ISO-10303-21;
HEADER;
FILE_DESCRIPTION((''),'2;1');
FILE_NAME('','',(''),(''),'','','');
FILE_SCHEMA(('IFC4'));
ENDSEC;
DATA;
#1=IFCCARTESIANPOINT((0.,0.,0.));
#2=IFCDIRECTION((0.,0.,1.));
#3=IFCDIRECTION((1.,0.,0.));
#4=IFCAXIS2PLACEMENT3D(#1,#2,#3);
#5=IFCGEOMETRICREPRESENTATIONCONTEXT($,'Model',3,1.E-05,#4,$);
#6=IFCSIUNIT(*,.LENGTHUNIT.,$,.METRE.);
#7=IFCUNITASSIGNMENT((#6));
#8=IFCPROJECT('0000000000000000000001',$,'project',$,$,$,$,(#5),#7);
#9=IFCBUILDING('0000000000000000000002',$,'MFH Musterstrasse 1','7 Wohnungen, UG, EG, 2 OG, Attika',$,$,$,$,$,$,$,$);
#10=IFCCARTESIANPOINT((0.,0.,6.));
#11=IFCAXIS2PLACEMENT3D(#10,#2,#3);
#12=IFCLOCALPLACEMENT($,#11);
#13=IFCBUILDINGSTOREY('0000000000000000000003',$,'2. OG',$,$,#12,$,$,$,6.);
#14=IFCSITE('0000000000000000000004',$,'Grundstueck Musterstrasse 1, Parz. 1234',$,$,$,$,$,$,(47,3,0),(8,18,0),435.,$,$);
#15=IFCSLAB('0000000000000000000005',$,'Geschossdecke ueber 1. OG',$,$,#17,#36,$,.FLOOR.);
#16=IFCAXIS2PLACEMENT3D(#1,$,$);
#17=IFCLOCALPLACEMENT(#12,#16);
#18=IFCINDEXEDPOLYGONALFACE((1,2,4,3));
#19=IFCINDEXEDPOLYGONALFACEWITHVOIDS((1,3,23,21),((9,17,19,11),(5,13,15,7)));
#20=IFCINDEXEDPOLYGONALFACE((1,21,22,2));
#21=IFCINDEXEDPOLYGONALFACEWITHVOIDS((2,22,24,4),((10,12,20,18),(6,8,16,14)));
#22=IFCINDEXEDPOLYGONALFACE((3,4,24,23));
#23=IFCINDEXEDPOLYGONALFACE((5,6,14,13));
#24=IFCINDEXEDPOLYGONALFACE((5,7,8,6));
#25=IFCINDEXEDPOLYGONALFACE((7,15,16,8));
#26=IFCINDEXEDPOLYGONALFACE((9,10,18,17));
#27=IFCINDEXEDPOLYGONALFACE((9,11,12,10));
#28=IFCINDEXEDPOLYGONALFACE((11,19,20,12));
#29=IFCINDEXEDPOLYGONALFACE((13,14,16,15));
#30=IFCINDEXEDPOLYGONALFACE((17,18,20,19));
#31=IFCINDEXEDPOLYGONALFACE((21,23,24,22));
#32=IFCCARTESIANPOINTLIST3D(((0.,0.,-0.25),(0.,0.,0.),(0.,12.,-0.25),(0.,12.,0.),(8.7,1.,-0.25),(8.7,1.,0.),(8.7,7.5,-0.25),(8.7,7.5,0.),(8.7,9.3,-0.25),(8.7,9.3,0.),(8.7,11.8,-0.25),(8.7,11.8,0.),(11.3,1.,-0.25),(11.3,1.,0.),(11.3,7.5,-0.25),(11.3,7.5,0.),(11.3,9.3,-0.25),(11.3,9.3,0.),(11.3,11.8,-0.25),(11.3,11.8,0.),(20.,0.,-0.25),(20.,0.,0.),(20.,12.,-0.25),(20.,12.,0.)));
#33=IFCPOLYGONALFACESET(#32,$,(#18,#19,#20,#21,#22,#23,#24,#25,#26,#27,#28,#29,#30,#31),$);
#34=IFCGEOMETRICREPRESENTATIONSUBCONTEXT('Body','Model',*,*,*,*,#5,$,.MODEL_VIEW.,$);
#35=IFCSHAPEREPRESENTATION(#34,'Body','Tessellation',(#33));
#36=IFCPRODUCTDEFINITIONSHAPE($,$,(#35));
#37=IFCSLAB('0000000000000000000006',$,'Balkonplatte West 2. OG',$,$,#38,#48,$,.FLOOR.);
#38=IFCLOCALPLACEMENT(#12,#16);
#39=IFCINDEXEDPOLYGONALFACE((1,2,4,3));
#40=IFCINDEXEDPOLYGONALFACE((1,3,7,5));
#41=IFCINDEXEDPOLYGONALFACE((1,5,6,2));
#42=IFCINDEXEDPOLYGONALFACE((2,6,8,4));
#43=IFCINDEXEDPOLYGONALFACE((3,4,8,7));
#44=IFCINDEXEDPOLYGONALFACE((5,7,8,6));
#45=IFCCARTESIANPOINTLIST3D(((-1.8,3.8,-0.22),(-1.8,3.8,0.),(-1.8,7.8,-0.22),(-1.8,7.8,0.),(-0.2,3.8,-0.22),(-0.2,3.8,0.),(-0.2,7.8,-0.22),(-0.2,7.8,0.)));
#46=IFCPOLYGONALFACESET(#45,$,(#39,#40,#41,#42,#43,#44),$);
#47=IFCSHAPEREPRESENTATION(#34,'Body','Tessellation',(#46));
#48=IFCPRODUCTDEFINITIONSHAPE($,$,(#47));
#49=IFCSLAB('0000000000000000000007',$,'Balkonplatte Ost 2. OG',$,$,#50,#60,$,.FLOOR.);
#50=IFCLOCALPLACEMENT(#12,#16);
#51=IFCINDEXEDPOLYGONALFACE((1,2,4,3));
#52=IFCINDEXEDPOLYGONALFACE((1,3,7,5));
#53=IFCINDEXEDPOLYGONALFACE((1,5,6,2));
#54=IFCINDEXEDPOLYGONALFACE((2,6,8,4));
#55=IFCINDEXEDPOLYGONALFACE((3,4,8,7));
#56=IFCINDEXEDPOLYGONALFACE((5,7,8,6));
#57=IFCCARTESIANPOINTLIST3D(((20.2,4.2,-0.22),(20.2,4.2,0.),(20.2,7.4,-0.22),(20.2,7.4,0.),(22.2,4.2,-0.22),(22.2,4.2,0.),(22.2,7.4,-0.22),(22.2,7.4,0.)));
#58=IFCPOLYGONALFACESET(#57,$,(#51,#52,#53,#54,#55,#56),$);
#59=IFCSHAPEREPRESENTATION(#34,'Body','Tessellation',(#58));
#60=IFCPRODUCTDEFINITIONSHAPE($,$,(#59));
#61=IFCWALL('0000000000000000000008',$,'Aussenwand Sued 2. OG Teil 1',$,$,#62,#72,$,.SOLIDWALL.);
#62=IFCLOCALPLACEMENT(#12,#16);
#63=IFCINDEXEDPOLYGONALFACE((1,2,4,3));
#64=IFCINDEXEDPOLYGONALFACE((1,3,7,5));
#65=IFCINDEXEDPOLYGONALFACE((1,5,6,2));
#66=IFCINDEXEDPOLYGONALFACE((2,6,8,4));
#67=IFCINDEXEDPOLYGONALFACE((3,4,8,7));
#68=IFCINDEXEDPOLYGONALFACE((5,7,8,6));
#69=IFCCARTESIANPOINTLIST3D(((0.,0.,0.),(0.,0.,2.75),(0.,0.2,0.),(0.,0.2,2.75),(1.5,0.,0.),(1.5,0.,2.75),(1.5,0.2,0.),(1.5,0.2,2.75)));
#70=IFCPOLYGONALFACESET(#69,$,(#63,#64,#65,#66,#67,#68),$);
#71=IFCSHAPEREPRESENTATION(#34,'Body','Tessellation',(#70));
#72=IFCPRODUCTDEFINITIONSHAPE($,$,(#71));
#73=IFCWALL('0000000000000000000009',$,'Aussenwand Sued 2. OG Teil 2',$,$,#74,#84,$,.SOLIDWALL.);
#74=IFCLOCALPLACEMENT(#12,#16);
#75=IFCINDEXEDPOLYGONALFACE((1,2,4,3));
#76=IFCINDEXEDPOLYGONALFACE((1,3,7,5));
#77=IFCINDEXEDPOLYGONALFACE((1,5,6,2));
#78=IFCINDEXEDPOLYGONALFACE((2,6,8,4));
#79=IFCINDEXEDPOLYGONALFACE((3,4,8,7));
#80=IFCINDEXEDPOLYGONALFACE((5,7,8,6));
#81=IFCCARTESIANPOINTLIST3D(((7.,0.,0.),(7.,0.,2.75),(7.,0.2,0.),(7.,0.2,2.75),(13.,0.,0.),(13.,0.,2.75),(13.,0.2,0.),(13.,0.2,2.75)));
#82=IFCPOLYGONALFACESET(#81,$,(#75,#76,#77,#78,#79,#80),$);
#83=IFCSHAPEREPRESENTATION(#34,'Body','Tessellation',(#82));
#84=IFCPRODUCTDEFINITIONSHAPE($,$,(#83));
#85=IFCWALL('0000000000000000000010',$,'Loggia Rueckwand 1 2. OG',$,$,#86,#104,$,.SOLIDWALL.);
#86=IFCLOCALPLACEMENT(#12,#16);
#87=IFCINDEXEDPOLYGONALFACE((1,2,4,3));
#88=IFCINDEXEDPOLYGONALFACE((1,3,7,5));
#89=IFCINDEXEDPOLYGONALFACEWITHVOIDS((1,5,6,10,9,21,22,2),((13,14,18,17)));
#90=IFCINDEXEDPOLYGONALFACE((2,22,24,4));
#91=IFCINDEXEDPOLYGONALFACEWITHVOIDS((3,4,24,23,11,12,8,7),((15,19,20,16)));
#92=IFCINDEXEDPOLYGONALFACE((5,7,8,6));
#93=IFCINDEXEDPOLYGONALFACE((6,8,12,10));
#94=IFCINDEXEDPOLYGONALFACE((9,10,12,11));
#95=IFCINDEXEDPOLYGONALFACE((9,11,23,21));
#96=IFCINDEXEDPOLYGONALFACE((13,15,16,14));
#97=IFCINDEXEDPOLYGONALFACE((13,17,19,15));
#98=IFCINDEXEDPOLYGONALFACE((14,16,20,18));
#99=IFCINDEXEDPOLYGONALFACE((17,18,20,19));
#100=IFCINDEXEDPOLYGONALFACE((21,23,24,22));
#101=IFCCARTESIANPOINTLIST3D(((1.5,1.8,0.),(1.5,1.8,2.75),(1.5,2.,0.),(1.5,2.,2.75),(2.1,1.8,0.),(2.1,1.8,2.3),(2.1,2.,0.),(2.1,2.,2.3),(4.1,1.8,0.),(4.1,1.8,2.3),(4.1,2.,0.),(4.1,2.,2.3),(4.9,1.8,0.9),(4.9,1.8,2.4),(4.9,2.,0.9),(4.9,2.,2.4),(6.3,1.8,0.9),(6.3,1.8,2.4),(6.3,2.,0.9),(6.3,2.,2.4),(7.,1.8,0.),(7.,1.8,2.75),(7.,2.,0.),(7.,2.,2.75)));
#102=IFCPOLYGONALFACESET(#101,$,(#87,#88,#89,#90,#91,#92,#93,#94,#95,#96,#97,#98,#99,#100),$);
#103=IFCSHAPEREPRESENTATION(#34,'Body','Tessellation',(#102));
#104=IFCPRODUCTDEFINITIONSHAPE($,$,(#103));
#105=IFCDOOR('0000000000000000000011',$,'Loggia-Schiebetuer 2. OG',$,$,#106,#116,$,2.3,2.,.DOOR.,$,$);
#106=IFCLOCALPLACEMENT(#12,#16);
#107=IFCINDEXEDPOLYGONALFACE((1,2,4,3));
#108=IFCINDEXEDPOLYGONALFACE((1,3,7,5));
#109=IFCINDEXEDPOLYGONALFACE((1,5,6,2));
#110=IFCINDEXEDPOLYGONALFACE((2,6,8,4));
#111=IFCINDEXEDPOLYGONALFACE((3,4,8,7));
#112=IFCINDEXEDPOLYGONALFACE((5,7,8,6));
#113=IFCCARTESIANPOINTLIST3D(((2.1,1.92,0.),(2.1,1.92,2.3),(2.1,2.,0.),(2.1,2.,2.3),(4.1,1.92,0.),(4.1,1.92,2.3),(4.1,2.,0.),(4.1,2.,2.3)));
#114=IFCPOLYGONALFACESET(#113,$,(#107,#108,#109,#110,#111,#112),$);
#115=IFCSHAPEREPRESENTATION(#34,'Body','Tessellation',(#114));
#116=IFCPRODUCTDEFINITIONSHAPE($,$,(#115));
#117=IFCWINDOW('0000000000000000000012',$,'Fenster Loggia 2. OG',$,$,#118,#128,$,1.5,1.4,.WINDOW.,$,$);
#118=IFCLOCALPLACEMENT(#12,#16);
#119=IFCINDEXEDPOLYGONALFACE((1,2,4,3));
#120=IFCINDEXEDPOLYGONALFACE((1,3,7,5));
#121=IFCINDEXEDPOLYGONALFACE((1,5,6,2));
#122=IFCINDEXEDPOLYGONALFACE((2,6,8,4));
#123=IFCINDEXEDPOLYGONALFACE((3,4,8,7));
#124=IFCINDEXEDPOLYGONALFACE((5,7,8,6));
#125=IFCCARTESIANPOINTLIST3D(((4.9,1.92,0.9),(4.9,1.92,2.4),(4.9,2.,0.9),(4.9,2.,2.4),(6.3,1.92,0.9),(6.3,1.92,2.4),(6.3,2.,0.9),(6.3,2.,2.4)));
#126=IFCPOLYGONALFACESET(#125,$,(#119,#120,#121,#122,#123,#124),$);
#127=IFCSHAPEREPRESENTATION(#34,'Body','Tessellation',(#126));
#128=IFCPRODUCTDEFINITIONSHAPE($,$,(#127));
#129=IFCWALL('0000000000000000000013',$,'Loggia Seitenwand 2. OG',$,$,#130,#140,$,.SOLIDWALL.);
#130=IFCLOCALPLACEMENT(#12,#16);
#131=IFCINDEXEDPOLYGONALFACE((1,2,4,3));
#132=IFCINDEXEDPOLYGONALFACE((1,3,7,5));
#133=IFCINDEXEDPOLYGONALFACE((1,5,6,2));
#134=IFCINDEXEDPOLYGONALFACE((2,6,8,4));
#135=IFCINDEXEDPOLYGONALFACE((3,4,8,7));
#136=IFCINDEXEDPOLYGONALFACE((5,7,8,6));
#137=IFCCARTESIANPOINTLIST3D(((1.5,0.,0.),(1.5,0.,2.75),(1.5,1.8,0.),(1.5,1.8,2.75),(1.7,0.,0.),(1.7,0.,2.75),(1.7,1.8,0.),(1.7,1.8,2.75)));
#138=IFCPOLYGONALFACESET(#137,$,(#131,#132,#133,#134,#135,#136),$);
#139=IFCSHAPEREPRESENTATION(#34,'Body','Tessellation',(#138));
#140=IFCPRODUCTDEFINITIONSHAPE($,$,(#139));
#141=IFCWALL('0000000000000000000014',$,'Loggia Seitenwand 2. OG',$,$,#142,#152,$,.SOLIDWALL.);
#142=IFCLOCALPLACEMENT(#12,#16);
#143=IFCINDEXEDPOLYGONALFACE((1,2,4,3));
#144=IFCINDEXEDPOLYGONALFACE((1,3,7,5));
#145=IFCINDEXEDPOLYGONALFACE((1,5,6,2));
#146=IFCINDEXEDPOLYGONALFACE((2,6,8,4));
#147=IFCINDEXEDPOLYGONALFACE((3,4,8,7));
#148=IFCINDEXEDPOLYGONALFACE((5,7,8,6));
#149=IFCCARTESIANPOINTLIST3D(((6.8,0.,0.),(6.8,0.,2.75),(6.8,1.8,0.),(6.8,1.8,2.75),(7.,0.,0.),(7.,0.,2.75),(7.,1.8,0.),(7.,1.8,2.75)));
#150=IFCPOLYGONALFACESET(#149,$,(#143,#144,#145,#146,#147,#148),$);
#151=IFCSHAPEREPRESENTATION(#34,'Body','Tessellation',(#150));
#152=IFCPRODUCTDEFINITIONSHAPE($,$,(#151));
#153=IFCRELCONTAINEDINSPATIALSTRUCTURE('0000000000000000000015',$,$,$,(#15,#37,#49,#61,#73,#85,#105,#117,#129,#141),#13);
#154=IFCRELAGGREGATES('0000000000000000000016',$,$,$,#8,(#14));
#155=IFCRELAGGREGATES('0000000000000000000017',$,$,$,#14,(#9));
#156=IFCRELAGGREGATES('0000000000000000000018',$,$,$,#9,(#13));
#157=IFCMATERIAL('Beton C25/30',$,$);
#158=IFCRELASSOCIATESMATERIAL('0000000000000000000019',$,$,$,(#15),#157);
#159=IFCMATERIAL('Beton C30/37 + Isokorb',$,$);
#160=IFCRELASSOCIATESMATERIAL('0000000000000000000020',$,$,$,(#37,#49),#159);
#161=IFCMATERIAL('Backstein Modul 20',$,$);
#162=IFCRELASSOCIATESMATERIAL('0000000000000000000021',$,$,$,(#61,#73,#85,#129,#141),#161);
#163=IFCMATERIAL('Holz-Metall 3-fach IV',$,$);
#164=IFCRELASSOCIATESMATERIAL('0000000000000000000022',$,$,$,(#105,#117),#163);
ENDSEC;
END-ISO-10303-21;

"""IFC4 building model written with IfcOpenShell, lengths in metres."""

from ifc_helpers import new_model, si_unit, frame, frame_2d, origin_with_axes, place, context, subcontext, project, spatial, polyline, rectangle, outline, extrude, material, element, fill, save


model = new_model("IFC4")

# Units and contexts
model_context = context("Model", 3, precision=1e-05, world=origin_with_axes())
body_context = subcontext(model_context, "Body", "Model", "MODEL_VIEW")
ifc_project = project(units=[si_unit("LENGTHUNIT", "METRE")], contexts=[model_context])

# Site, building, storey
site = spatial("IfcSite", under=ifc_project, Name="Grundstueck Musterstrasse 1, Parz. 1234", RefLatitude=(47, 3, 0), RefLongitude=(8, 18, 0), RefElevation=435.0)
building = spatial("IfcBuilding", under=site, Name="MFH Musterstrasse 1", Description="7 Wohnungen, UG, EG, 2 OG, Attika")
storey_placement = place(None, frame((0.0, 0.0, 6.0), z_axis=(0.0, 0.0, 1.0), x_axis=(1.0, 0.0, 0.0)))
storey = spatial("IfcBuildingStorey", under=building, at=storey_placement, Name="2. OG", Elevation=6.0)

# Slab, openings
ifc_material_1 = material(Name="Beton C25/30")
slab_1_placement = place(storey_placement, frame((0.0, 0.0, -0.25), z_axis=(0.0, 0.0, 1.0), x_axis=(1.0, 0.0, 0.0)))
slab_1 = element("IfcSlab", 1, at=slab_1_placement, inside=storey, material=ifc_material_1, Name="Geschossdecke ueber 1. OG", PredefinedType="FLOOR", context=body_context, shape_type="SweptSolid", body=[
    extrude(outline(polyline([(0.0, 0.0), (20.0, 0.0), (20.0, 12.0), (0.0, 12.0), (0.0, 0.0)])), origin_with_axes(), (0.0, 0.0, 1.0), 0.25),
])
opening_1_placement = place(slab_1_placement, frame((8.7, 1.0, -0.01), z_axis=(0.0, 0.0, 1.0), x_axis=(1.0, 0.0, 0.0)))
element("IfcOpeningElement", 2, at=opening_1_placement, cuts=slab_1, context=body_context, shape_type="SweptSolid", body=[
    extrude(rectangle(XDim=2.6, YDim=6.5, at=frame_2d((1.3, 3.25))), origin_with_axes(), (0.0, 0.0, 1.0), 0.27),
])
opening_2_placement = place(slab_1_placement, frame((8.7, 9.3, -0.01), z_axis=(0.0, 0.0, 1.0), x_axis=(1.0, 0.0, 0.0)))
element("IfcOpeningElement", 3, at=opening_2_placement, cuts=slab_1, context=body_context, shape_type="SweptSolid", body=[
    extrude(rectangle(XDim=2.6, YDim=2.5, at=frame_2d((1.3, 1.25))), origin_with_axes(), (0.0, 0.0, 1.0), 0.27),
])

# Slabs
ifc_material_2 = material(Name="Beton C30/37 + Isokorb")
slab_2_placement = place(storey_placement, frame((0.0, 0.0, -0.22), z_axis=(0.0, 0.0, 1.0), x_axis=(1.0, 0.0, 0.0)))
element("IfcSlab", 4, at=slab_2_placement, inside=storey, material=ifc_material_2, Name="Balkonplatte West 2. OG", PredefinedType="FLOOR", context=body_context, shape_type="SweptSolid", body=[
    extrude(outline(polyline([(-1.8, 3.8), (-0.2, 3.8), (-0.2, 7.8), (-1.8, 7.8), (-1.8, 3.8)])), origin_with_axes(), (0.0, 0.0, 1.0), 0.22),
])
slab_3_placement = place(storey_placement, frame((0.0, 0.0, -0.22), z_axis=(0.0, 0.0, 1.0), x_axis=(1.0, 0.0, 0.0)))
element("IfcSlab", 5, at=slab_3_placement, inside=storey, material=ifc_material_2, Name="Balkonplatte Ost 2. OG", PredefinedType="FLOOR", context=body_context, shape_type="SweptSolid", body=[
    extrude(outline(polyline([(20.2, 4.2), (22.2, 4.2), (22.2, 7.4), (20.2, 7.4), (20.2, 4.2)])), origin_with_axes(), (0.0, 0.0, 1.0), 0.22),
])

# Walls
ifc_material_3 = material(Name="Backstein Modul 20")
wall_1_placement = place(storey_placement, origin_with_axes())
element("IfcWall", 6, at=wall_1_placement, inside=storey, material=ifc_material_3, Name="Aussenwand Sued 2. OG Teil 1", PredefinedType="SOLIDWALL", context=body_context, shape_type="SweptSolid", body=[
    extrude(rectangle(XDim=1.5, YDim=0.2, at=frame_2d((0.75, 0.1))), origin_with_axes(), (0.0, 0.0, 1.0), 2.75),
])
wall_2_placement = place(storey_placement, frame((7.0, 0.0, 0.0), z_axis=(0.0, 0.0, 1.0), x_axis=(1.0, 0.0, 0.0)))
element("IfcWall", 7, at=wall_2_placement, inside=storey, material=ifc_material_3, Name="Aussenwand Sued 2. OG Teil 2", PredefinedType="SOLIDWALL", context=body_context, shape_type="SweptSolid", body=[
    extrude(rectangle(XDim=6.0, YDim=0.2, at=frame_2d((3.0, 0.1))), origin_with_axes(), (0.0, 0.0, 1.0), 2.75),
])

# Wall, openings, door, window
wall_3_placement = place(storey_placement, frame((1.5, 1.8, 0.0), z_axis=(0.0, 0.0, 1.0), x_axis=(1.0, 0.0, 0.0)))
wall_3 = element("IfcWall", 8, at=wall_3_placement, inside=storey, material=ifc_material_3, Name="Loggia Rueckwand 1 2. OG", PredefinedType="SOLIDWALL", context=body_context, shape_type="SweptSolid", body=[
    extrude(rectangle(XDim=5.5, YDim=0.2, at=frame_2d((2.75, 0.1))), origin_with_axes(), (0.0, 0.0, 1.0), 2.75),
])
opening_3_placement = place(wall_3_placement, frame((0.6, -0.21, 0.0), z_axis=(0.0, 0.0, 1.0), x_axis=(1.0, 0.0, 0.0)))
opening_3 = element("IfcOpeningElement", 9, at=opening_3_placement, cuts=wall_3, context=body_context, shape_type="SweptSolid", body=[
    extrude(rectangle(XDim=2.0, YDim=0.42, at=frame_2d((1.0, 0.21))), origin_with_axes(), (0.0, 0.0, 1.0), 2.3),
])
opening_4_placement = place(wall_3_placement, frame((3.4, -0.21, 0.9), z_axis=(0.0, 0.0, 1.0), x_axis=(1.0, 0.0, 0.0)))
opening_4 = element("IfcOpeningElement", 10, at=opening_4_placement, cuts=wall_3, context=body_context, shape_type="SweptSolid", body=[
    extrude(rectangle(XDim=1.4, YDim=0.42, at=frame_2d((0.7, 0.21))), origin_with_axes(), (0.0, 0.0, 1.0), 1.5),
])
ifc_material_4 = material(Name="Holz-Metall 3-fach IV")
door_1_placement = place(storey_placement, frame((2.1, 1.92, 0.0), z_axis=(0.0, 0.0, 1.0), x_axis=(1.0, 0.0, 0.0)))
door_1 = element("IfcDoor", 11, at=door_1_placement, inside=storey, material=ifc_material_4, Name="Loggia-Schiebetuer 2. OG", OverallHeight=2.3, OverallWidth=2.0, PredefinedType="DOOR", context=body_context, shape_type="SweptSolid", body=[
    extrude(rectangle(XDim=2.0, YDim=0.08, at=frame_2d((1.0, 0.04))), origin_with_axes(), (0.0, 0.0, 1.0), 2.3),
])
fill(opening_3, door_1)
window_1_placement = place(storey_placement, frame((4.9, 1.92, 0.9), z_axis=(0.0, 0.0, 1.0), x_axis=(1.0, 0.0, 0.0)))
window_1 = element("IfcWindow", 12, at=window_1_placement, inside=storey, material=ifc_material_4, Name="Fenster Loggia 2. OG", OverallHeight=1.5, OverallWidth=1.4, PredefinedType="WINDOW", context=body_context, shape_type="SweptSolid", body=[
    extrude(rectangle(XDim=1.4, YDim=0.08, at=frame_2d((0.7, 0.04))), origin_with_axes(), (0.0, 0.0, 1.0), 1.5),
])
fill(opening_4, window_1)

# Walls
for number, where, z_axis, x_axis, name in (
    (13, (1.5, 0.2, 0.0), (0.0, 0.0, 1.0), (1.0, 0.0, 0.0), "Loggia Seitenwand 2. OG"),
    (14, (6.8, 0.2, 0.0), (0.0, 0.0, 1.0), (1.0, 0.0, 0.0), "Loggia Seitenwand 2. OG"),
):
    element("IfcWall", number, at=place(storey_placement, frame(where, z_axis=z_axis, x_axis=x_axis)), inside=storey, material=ifc_material_3, Name=name, PredefinedType="SOLIDWALL", context=body_context, shape_type="SweptSolid", body=[
        extrude(rectangle(XDim=0.2, YDim=1.8, at=frame_2d((0.1, 0.7))), origin_with_axes(), (0.0, 0.0, 1.0), 2.75),
    ])

save(model, "model.ifc")
